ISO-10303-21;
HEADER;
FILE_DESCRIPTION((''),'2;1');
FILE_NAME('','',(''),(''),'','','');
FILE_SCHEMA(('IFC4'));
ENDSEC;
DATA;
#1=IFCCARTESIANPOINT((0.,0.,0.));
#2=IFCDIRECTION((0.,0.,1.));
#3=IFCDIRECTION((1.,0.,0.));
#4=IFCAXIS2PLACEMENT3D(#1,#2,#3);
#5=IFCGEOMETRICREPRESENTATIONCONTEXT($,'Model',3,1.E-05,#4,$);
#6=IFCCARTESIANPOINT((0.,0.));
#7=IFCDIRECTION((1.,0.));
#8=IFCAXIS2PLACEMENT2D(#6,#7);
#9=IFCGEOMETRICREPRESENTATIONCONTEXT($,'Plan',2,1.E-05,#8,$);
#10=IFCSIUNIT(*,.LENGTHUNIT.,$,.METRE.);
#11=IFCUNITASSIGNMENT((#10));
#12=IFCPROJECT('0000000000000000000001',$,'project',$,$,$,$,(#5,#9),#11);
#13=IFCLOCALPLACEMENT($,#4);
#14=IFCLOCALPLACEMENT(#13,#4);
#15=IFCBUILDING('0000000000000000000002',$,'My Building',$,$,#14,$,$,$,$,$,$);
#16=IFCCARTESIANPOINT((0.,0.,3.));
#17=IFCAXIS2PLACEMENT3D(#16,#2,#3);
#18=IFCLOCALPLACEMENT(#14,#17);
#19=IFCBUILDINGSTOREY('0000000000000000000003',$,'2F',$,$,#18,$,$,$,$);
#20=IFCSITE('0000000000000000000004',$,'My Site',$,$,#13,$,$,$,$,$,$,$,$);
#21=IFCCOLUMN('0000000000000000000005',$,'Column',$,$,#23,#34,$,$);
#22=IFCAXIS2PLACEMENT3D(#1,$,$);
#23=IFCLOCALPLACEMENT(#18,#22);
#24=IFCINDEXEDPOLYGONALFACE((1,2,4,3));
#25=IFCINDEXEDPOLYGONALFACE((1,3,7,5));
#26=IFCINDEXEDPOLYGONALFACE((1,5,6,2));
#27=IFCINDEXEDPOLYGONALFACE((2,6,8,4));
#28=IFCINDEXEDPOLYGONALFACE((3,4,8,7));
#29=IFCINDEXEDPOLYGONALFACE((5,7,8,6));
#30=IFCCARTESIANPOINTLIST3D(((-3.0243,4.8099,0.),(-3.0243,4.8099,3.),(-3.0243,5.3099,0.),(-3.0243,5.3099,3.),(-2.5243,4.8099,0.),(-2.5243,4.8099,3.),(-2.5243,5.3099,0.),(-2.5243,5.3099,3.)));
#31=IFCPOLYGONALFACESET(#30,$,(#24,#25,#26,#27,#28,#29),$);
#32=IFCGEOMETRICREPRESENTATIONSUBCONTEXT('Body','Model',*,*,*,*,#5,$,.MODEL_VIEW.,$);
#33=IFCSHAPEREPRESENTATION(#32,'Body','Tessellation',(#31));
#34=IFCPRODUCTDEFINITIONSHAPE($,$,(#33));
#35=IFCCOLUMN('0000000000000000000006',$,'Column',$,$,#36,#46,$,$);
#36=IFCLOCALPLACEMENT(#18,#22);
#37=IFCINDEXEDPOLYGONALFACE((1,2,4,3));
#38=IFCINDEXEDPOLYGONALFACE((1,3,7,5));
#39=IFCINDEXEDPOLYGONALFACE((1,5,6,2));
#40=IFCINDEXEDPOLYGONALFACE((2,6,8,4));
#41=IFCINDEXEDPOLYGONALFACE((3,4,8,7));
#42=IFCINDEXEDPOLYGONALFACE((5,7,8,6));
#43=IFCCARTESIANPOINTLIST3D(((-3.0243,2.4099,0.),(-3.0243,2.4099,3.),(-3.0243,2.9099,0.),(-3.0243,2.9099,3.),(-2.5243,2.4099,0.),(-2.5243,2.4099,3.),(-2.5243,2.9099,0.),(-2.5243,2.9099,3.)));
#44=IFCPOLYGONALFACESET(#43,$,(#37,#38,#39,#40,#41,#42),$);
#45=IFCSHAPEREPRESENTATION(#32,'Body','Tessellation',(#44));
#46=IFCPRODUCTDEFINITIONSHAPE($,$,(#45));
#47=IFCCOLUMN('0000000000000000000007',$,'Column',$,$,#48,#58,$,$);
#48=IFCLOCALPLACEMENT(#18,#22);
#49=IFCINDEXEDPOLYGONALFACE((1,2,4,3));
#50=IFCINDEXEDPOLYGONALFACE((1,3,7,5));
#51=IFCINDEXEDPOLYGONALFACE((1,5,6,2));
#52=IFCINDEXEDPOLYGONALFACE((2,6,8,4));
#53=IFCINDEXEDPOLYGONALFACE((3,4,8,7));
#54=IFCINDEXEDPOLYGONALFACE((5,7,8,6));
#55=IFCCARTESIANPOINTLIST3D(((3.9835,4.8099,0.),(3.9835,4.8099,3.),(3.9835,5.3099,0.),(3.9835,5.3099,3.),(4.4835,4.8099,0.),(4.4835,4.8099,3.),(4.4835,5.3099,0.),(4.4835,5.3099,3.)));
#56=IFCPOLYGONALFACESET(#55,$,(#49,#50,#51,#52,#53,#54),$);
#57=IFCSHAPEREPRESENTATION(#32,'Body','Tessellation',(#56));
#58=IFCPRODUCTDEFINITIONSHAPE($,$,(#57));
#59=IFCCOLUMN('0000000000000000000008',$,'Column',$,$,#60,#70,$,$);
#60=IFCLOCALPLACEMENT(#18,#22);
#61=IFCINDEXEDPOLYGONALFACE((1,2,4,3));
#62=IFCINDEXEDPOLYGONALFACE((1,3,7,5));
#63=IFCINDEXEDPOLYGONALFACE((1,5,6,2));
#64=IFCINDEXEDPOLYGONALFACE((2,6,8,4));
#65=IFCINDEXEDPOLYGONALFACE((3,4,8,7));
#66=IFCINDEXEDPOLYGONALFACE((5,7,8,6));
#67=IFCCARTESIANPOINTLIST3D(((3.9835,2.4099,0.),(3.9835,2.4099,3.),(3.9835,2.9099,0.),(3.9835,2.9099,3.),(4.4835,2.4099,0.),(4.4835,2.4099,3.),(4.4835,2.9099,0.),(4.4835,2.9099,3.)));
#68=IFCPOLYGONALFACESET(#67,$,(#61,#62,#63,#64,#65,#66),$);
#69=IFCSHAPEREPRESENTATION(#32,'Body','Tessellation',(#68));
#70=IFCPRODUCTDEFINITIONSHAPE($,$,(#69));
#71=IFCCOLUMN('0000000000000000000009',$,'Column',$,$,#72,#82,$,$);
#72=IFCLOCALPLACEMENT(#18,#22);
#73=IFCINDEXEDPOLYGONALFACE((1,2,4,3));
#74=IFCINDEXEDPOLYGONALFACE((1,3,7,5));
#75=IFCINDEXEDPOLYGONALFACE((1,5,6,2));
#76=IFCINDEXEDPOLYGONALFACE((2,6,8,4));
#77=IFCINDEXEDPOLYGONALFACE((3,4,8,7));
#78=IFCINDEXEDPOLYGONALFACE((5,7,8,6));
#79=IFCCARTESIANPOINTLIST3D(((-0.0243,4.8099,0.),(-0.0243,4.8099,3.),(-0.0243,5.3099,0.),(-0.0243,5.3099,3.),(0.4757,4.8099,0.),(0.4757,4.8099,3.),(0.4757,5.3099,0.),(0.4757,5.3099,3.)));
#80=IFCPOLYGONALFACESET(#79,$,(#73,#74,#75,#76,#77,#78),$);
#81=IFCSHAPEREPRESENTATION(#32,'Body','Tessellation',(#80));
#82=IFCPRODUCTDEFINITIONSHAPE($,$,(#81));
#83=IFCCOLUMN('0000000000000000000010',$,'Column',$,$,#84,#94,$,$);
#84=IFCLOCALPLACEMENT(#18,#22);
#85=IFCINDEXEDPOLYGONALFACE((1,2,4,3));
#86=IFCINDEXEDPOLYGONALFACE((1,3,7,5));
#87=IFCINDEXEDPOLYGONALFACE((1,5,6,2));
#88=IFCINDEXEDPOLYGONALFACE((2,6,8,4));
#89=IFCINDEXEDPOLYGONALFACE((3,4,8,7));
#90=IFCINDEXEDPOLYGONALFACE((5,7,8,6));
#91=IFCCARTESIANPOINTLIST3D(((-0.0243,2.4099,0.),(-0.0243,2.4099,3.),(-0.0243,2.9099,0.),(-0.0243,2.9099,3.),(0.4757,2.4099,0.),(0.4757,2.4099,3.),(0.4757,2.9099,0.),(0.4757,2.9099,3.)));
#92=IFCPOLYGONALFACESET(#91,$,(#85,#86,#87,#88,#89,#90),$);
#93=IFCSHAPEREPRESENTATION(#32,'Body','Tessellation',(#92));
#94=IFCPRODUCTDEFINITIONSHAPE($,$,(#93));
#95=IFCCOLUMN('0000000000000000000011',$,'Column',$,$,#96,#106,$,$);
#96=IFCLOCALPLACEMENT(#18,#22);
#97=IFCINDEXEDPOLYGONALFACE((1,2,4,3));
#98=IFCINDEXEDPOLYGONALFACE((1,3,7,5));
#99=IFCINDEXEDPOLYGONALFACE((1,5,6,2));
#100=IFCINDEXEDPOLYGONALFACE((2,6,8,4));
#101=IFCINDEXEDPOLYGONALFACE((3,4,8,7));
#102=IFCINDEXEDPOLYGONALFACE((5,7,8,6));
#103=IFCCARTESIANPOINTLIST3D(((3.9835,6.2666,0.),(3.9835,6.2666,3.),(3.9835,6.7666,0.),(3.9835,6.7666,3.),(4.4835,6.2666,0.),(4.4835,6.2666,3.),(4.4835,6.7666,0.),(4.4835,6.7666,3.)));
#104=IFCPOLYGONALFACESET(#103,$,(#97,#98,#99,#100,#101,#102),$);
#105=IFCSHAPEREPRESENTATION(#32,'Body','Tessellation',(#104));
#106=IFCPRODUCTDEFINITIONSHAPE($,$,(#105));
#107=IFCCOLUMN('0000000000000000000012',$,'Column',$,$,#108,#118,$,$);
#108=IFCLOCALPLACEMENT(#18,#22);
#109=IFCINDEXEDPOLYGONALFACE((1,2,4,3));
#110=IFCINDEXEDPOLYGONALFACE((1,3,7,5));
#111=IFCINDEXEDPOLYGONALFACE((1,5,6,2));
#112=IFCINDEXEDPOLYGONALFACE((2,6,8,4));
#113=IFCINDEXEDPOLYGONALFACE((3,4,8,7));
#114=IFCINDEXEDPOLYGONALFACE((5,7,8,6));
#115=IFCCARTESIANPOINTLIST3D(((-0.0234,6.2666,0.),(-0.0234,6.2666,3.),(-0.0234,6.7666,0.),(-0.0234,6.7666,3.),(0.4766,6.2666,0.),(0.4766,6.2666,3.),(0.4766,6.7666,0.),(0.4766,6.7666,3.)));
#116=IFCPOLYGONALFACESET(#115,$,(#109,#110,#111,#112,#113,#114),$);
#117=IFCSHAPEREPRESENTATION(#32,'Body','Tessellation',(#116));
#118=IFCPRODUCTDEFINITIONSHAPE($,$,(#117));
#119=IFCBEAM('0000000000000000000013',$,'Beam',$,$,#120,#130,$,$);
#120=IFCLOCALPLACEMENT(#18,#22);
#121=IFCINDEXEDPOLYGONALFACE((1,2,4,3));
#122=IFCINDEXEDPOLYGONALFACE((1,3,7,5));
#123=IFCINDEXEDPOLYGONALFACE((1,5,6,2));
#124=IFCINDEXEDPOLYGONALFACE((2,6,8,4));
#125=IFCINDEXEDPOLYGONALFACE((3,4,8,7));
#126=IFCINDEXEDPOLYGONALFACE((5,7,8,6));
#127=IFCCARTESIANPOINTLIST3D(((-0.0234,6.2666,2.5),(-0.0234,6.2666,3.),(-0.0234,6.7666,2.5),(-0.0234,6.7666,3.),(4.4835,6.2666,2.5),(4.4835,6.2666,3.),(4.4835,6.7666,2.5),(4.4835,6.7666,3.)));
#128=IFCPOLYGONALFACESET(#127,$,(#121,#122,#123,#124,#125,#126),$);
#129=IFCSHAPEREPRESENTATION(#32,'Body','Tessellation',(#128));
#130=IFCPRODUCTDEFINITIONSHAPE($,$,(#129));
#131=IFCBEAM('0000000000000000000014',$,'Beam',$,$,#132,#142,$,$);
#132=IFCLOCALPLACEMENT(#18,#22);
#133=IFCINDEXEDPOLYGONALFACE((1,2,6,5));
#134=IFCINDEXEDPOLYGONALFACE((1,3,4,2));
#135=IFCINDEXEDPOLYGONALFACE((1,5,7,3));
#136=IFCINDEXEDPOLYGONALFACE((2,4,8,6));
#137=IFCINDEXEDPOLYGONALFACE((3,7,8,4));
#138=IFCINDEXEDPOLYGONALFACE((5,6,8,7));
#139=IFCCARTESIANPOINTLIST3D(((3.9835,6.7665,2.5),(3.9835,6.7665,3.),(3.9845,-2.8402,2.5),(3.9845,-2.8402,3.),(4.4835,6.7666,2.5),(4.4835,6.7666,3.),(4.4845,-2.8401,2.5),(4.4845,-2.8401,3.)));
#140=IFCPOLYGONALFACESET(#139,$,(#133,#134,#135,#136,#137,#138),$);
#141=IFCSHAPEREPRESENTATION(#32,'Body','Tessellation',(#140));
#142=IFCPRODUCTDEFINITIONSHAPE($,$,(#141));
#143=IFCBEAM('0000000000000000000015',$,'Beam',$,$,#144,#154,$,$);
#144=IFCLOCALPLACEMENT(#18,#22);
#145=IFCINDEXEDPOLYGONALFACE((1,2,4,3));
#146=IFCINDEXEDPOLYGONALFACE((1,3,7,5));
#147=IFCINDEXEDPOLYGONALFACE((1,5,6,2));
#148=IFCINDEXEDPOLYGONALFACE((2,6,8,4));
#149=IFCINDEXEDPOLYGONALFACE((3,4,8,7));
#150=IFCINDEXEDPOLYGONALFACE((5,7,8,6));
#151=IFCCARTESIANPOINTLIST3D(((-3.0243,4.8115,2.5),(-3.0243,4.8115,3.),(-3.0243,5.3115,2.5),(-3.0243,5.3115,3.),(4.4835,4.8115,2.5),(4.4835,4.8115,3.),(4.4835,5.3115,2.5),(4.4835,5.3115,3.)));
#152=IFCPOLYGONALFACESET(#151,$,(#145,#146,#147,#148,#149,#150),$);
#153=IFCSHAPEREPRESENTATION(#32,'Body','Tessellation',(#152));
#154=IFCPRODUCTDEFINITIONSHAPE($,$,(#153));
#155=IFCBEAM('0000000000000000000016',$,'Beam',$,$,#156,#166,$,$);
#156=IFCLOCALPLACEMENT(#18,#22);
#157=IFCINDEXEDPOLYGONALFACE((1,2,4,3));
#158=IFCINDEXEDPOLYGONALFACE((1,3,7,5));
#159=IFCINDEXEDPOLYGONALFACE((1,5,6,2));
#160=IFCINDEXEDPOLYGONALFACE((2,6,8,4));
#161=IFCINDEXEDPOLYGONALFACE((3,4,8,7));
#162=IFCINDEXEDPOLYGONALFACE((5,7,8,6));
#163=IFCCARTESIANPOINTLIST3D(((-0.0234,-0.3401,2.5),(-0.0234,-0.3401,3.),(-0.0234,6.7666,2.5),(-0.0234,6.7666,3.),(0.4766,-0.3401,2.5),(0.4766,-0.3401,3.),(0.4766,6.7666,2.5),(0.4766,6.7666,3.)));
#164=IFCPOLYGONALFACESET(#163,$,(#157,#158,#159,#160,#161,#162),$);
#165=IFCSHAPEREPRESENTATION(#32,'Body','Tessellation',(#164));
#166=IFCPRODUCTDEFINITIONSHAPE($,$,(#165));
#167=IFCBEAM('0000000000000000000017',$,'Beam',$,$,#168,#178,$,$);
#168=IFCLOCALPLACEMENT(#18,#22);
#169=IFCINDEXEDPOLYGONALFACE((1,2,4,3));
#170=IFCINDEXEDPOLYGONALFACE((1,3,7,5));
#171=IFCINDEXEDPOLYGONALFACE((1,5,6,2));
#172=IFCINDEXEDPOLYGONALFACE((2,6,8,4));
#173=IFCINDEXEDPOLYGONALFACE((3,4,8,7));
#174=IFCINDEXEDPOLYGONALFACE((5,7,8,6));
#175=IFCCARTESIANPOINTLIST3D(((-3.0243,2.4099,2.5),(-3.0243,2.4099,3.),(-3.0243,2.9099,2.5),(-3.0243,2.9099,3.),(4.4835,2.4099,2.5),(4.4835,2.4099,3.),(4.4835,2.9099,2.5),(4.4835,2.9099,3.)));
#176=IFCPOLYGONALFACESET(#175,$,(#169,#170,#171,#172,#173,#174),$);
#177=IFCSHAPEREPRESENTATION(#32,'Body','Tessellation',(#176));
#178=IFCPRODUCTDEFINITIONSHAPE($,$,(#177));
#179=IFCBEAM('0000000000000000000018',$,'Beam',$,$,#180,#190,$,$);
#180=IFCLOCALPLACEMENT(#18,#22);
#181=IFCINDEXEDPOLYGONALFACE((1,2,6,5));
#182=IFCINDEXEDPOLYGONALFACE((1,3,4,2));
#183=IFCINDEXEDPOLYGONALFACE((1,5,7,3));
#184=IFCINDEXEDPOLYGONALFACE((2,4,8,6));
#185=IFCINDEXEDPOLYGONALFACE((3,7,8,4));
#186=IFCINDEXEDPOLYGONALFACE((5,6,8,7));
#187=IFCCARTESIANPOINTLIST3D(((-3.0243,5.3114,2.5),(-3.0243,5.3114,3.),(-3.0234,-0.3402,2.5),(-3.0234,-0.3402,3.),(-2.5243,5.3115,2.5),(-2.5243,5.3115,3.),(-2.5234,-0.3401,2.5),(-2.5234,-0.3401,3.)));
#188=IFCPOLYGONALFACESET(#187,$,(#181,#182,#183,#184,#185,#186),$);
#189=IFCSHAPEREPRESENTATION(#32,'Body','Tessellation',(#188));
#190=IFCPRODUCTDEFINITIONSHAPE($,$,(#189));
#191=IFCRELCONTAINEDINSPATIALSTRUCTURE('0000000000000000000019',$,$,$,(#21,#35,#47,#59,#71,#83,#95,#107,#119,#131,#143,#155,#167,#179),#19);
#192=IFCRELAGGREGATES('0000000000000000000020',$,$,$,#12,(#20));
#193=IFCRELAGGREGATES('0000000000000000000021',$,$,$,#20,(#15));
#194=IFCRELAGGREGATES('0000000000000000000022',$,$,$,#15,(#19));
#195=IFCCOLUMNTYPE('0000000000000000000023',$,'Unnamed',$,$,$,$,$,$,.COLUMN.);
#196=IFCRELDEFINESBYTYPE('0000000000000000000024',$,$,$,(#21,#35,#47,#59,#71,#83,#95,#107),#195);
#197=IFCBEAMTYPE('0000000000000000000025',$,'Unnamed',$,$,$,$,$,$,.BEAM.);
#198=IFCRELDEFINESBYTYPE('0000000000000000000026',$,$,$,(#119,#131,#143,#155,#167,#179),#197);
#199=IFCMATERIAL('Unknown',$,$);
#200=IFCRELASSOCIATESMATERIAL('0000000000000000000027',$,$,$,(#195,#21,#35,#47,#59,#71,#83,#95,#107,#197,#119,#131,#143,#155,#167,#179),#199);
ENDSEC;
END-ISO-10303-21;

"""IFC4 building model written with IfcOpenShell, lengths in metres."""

from ifc_helpers import new_model, si_unit, frame, origin_with_axes, origin_2d_with_axis, place, context, subcontext, project, spatial, rectangle, extrude, material, material_profile, profile_set, profile_usage, type_object, element, save


model = new_model("IFC4")

# Units and contexts
model_context = context("Model", 3, precision=1e-05, world=origin_with_axes())
plan_context = context("Plan", 2, precision=1e-05, world=origin_2d_with_axis())
body_context_1 = subcontext(model_context, "Body", "Model", "MODEL_VIEW")
ifc_project = project(units=[si_unit("LENGTHUNIT", "METRE")], contexts=[model_context, plan_context])

# Site, building, storey
site_placement = place(None, origin_with_axes())
site = spatial("IfcSite", under=ifc_project, at=site_placement, Name="My Site")
building_placement = place(site_placement, origin_with_axes())
building = spatial("IfcBuilding", under=site, at=building_placement, Name="My Building")
storey_placement = place(building_placement, frame((0.0, 0.0, 3.0), z_axis=(0.0, 0.0, 1.0), x_axis=(1.0, 0.0, 0.0)))
storey = spatial("IfcBuildingStorey", under=building, at=storey_placement, Name="2F")

# Columns
ifc_material = material(Name="Unknown")
ifc_material_profile_1 = material_profile(ifc_material, rectangle(XDim=0.5, YDim=0.5))
ifc_profile_set_1 = profile_set([ifc_material_profile_1])
ifc_profile_usage_1 = profile_usage(ifc_profile_set_1, cardinal=5)
column_type = type_object("IfcColumnType", Name="Unnamed", PredefinedType="COLUMN", material=ifc_profile_set_1)
column_1_placement = place(storey_placement, frame((-2.7743, 5.0599, 0.0), z_axis=(0.0, 0.0, 1.0), x_axis=(1.0, 0.0, 0.0)))
element("IfcColumn", 1, at=column_1_placement, inside=storey, type_object=column_type, material=ifc_profile_usage_1, Name="Column", context=body_context_1, shape_type="SweptSolid", body=[
    extrude(rectangle(XDim=0.5, YDim=0.5), origin_with_axes(), (0.0, 0.0, 1.0), 3.0),
])
ifc_profile_usage_2 = profile_usage(ifc_profile_set_1, cardinal=5)
column_2_placement = place(storey_placement, frame((-2.7743, 2.6599, 0.0), z_axis=(0.0, 0.0, 1.0), x_axis=(1.0, 0.0, 0.0)))
element("IfcColumn", 2, at=column_2_placement, inside=storey, type_object=column_type, material=ifc_profile_usage_2, Name="Column", context=body_context_1, shape_type="SweptSolid", body=[
    extrude(rectangle(XDim=0.5, YDim=0.5), origin_with_axes(), (0.0, 0.0, 1.0), 3.0),
])
ifc_profile_usage_3 = profile_usage(ifc_profile_set_1, cardinal=5)
column_3_placement = place(storey_placement, frame((4.2335, 5.0599, 0.0), z_axis=(0.0, 0.0, 1.0), x_axis=(1.0, 0.0, 0.0)))
element("IfcColumn", 3, at=column_3_placement, inside=storey, type_object=column_type, material=ifc_profile_usage_3, Name="Column", context=body_context_1, shape_type="SweptSolid", body=[
    extrude(rectangle(XDim=0.5, YDim=0.5), origin_with_axes(), (0.0, 0.0, 1.0), 3.0),
])
ifc_profile_usage_4 = profile_usage(ifc_profile_set_1, cardinal=5)
column_4_placement = place(storey_placement, frame((4.2335, 2.6599, 0.0), z_axis=(0.0, 0.0, 1.0), x_axis=(1.0, 0.0, 0.0)))
element("IfcColumn", 4, at=column_4_placement, inside=storey, type_object=column_type, material=ifc_profile_usage_4, Name="Column", context=body_context_1, shape_type="SweptSolid", body=[
    extrude(rectangle(XDim=0.5, YDim=0.5), origin_with_axes(), (0.0, 0.0, 1.0), 3.0),
])
ifc_profile_usage_5 = profile_usage(ifc_profile_set_1, cardinal=5)
column_5_placement = place(storey_placement, frame((0.2257, 5.0599, 0.0), z_axis=(0.0, 0.0, 1.0), x_axis=(1.0, 0.0, 0.0)))
element("IfcColumn", 5, at=column_5_placement, inside=storey, type_object=column_type, material=ifc_profile_usage_5, Name="Column", context=body_context_1, shape_type="SweptSolid", body=[
    extrude(rectangle(XDim=0.5, YDim=0.5), origin_with_axes(), (0.0, 0.0, 1.0), 3.0),
])
ifc_profile_usage_6 = profile_usage(ifc_profile_set_1, cardinal=5)
column_6_placement = place(storey_placement, frame((0.2257, 2.6599, 0.0), z_axis=(0.0, 0.0, 1.0), x_axis=(1.0, 0.0, 0.0)))
element("IfcColumn", 6, at=column_6_placement, inside=storey, type_object=column_type, material=ifc_profile_usage_6, Name="Column", context=body_context_1, shape_type="SweptSolid", body=[
    extrude(rectangle(XDim=0.5, YDim=0.5), origin_with_axes(), (0.0, 0.0, 1.0), 3.0),
])
ifc_profile_usage_7 = profile_usage(ifc_profile_set_1, cardinal=5)
column_7_placement = place(storey_placement, frame((4.2335, 6.5166, 0.0), z_axis=(0.0, 0.0, 1.0), x_axis=(1.0, 0.0, 0.0)))
element("IfcColumn", 7, at=column_7_placement, inside=storey, type_object=column_type, material=ifc_profile_usage_7, Name="Column", context=body_context_1, shape_type="SweptSolid", body=[
    extrude(rectangle(XDim=0.5, YDim=0.5), origin_with_axes(), (0.0, 0.0, 1.0), 3.0),
])
ifc_profile_usage_8 = profile_usage(ifc_profile_set_1, cardinal=5)
column_8_placement = place(storey_placement, frame((0.2266, 6.5166, 0.0), z_axis=(0.0, 0.0, 1.0), x_axis=(1.0, 0.0, 0.0)))
element("IfcColumn", 8, at=column_8_placement, inside=storey, type_object=column_type, material=ifc_profile_usage_8, Name="Column", context=body_context_1, shape_type="SweptSolid", body=[
    extrude(rectangle(XDim=0.5, YDim=0.5), origin_with_axes(), (0.0, 0.0, 1.0), 3.0),
])

# Beams
ifc_material_profile_2 = material_profile(ifc_material, rectangle(XDim=0.5, YDim=0.5))
ifc_profile_set_2 = profile_set([ifc_material_profile_2])
ifc_profile_usage_9 = profile_usage(ifc_profile_set_2, cardinal=7)
beam_type = type_object("IfcBeamType", Name="Unnamed", PredefinedType="BEAM", material=ifc_profile_set_2)
beam_1_placement = place(storey_placement, frame((4.4835, 6.2666, 3.0), z_axis=(-1.0, 0.0, 0.0), x_axis=(0.0, -1.0, 0.0)))
element("IfcBeam", 9, at=beam_1_placement, inside=storey, type_object=beam_type, material=ifc_profile_usage_9, Name="Beam", context=body_context_1, shape_type="SweptSolid", body=[
    extrude(rectangle(XDim=0.5, YDim=0.5), frame((-0.25, -0.25, 0.0), z_axis=(0.0, 0.0, 1.0), x_axis=(1.0, 0.0, 0.0)), (0.0, 0.0, 1.0), 4.5069),
])
ifc_profile_usage_10 = profile_usage(ifc_profile_set_2, cardinal=7)
beam_2_placement = place(storey_placement, frame((4.4835, 6.7666, 3.0), z_axis=(0.000095, -1.0, 0.0), x_axis=(1.0, 0.000095, 0.0)))
element("IfcBeam", 10, at=beam_2_placement, inside=storey, type_object=beam_type, material=ifc_profile_usage_10, Name="Beam", context=body_context_1, shape_type="SweptSolid", body=[
    extrude(rectangle(XDim=0.5, YDim=0.5), frame((-0.25, -0.25, 0.0), z_axis=(0.0, 0.0, 1.0), x_axis=(1.0, 0.0, 0.0)), (0.0, 0.0, 1.0), 9.6067),
])
ifc_profile_usage_11 = profile_usage(ifc_profile_set_2, cardinal=7)
beam_3_placement = place(storey_placement, frame((-3.0243, 5.3115, 3.0), z_axis=(1.0, 0.0, 0.0), x_axis=(0.0, 1.0, 0.0)))
element("IfcBeam", 11, at=beam_3_placement, inside=storey, type_object=beam_type, material=ifc_profile_usage_11, Name="Beam", context=body_context_1, shape_type="SweptSolid", body=[
    extrude(rectangle(XDim=0.5, YDim=0.5), frame((-0.25, -0.25, 0.0), z_axis=(0.0, 0.0, 1.0), x_axis=(1.0, 0.0, 0.0)), (0.0, 0.0, 1.0), 7.5078),
])
ifc_profile_usage_12 = profile_usage(ifc_profile_set_2, cardinal=7)
beam_4_placement = place(storey_placement, frame((0.4766, 6.7666, 3.0), z_axis=(0.0, -1.0, 0.0), x_axis=(1.0, 0.0, 0.0)))
element("IfcBeam", 12, at=beam_4_placement, inside=storey, type_object=beam_type, material=ifc_profile_usage_12, Name="Beam", context=body_context_1, shape_type="SweptSolid", body=[
    extrude(rectangle(XDim=0.5, YDim=0.5), frame((-0.25, -0.25, 0.0), z_axis=(0.0, 0.0, 1.0), x_axis=(1.0, 0.0, 0.0)), (0.0, 0.0, 1.0), 7.1067),
])
ifc_profile_usage_13 = profile_usage(ifc_profile_set_2, cardinal=7)
beam_5_placement = place(storey_placement, frame((-3.0243, 2.9099, 3.0), z_axis=(1.0, 0.0, 0.0), x_axis=(0.0, 1.0, 0.0)))
element("IfcBeam", 13, at=beam_5_placement, inside=storey, type_object=beam_type, material=ifc_profile_usage_13, Name="Beam", context=body_context_1, shape_type="SweptSolid", body=[
    extrude(rectangle(XDim=0.5, YDim=0.5), frame((-0.25, -0.25, 0.0), z_axis=(0.0, 0.0, 1.0), x_axis=(1.0, 0.0, 0.0)), (0.0, 0.0, 1.0), 7.5078),
])
ifc_profile_usage_14 = profile_usage(ifc_profile_set_2, cardinal=7)
beam_6_placement = place(storey_placement, frame((-2.5243, 5.3115, 3.0), z_axis=(0.000161, -1.0, 0.0), x_axis=(1.0, 0.000161, 0.0)))
element("IfcBeam", 14, at=beam_6_placement, inside=storey, type_object=beam_type, material=ifc_profile_usage_14, Name="Beam", context=body_context_1, shape_type="SweptSolid", body=[
    extrude(rectangle(XDim=0.5, YDim=0.5), frame((-0.25, -0.25, 0.0), z_axis=(0.0, 0.0, 1.0), x_axis=(1.0, 0.0, 0.0)), (0.0, 0.0, 1.0), 5.6516),
])

save(model, "model.ifc")
